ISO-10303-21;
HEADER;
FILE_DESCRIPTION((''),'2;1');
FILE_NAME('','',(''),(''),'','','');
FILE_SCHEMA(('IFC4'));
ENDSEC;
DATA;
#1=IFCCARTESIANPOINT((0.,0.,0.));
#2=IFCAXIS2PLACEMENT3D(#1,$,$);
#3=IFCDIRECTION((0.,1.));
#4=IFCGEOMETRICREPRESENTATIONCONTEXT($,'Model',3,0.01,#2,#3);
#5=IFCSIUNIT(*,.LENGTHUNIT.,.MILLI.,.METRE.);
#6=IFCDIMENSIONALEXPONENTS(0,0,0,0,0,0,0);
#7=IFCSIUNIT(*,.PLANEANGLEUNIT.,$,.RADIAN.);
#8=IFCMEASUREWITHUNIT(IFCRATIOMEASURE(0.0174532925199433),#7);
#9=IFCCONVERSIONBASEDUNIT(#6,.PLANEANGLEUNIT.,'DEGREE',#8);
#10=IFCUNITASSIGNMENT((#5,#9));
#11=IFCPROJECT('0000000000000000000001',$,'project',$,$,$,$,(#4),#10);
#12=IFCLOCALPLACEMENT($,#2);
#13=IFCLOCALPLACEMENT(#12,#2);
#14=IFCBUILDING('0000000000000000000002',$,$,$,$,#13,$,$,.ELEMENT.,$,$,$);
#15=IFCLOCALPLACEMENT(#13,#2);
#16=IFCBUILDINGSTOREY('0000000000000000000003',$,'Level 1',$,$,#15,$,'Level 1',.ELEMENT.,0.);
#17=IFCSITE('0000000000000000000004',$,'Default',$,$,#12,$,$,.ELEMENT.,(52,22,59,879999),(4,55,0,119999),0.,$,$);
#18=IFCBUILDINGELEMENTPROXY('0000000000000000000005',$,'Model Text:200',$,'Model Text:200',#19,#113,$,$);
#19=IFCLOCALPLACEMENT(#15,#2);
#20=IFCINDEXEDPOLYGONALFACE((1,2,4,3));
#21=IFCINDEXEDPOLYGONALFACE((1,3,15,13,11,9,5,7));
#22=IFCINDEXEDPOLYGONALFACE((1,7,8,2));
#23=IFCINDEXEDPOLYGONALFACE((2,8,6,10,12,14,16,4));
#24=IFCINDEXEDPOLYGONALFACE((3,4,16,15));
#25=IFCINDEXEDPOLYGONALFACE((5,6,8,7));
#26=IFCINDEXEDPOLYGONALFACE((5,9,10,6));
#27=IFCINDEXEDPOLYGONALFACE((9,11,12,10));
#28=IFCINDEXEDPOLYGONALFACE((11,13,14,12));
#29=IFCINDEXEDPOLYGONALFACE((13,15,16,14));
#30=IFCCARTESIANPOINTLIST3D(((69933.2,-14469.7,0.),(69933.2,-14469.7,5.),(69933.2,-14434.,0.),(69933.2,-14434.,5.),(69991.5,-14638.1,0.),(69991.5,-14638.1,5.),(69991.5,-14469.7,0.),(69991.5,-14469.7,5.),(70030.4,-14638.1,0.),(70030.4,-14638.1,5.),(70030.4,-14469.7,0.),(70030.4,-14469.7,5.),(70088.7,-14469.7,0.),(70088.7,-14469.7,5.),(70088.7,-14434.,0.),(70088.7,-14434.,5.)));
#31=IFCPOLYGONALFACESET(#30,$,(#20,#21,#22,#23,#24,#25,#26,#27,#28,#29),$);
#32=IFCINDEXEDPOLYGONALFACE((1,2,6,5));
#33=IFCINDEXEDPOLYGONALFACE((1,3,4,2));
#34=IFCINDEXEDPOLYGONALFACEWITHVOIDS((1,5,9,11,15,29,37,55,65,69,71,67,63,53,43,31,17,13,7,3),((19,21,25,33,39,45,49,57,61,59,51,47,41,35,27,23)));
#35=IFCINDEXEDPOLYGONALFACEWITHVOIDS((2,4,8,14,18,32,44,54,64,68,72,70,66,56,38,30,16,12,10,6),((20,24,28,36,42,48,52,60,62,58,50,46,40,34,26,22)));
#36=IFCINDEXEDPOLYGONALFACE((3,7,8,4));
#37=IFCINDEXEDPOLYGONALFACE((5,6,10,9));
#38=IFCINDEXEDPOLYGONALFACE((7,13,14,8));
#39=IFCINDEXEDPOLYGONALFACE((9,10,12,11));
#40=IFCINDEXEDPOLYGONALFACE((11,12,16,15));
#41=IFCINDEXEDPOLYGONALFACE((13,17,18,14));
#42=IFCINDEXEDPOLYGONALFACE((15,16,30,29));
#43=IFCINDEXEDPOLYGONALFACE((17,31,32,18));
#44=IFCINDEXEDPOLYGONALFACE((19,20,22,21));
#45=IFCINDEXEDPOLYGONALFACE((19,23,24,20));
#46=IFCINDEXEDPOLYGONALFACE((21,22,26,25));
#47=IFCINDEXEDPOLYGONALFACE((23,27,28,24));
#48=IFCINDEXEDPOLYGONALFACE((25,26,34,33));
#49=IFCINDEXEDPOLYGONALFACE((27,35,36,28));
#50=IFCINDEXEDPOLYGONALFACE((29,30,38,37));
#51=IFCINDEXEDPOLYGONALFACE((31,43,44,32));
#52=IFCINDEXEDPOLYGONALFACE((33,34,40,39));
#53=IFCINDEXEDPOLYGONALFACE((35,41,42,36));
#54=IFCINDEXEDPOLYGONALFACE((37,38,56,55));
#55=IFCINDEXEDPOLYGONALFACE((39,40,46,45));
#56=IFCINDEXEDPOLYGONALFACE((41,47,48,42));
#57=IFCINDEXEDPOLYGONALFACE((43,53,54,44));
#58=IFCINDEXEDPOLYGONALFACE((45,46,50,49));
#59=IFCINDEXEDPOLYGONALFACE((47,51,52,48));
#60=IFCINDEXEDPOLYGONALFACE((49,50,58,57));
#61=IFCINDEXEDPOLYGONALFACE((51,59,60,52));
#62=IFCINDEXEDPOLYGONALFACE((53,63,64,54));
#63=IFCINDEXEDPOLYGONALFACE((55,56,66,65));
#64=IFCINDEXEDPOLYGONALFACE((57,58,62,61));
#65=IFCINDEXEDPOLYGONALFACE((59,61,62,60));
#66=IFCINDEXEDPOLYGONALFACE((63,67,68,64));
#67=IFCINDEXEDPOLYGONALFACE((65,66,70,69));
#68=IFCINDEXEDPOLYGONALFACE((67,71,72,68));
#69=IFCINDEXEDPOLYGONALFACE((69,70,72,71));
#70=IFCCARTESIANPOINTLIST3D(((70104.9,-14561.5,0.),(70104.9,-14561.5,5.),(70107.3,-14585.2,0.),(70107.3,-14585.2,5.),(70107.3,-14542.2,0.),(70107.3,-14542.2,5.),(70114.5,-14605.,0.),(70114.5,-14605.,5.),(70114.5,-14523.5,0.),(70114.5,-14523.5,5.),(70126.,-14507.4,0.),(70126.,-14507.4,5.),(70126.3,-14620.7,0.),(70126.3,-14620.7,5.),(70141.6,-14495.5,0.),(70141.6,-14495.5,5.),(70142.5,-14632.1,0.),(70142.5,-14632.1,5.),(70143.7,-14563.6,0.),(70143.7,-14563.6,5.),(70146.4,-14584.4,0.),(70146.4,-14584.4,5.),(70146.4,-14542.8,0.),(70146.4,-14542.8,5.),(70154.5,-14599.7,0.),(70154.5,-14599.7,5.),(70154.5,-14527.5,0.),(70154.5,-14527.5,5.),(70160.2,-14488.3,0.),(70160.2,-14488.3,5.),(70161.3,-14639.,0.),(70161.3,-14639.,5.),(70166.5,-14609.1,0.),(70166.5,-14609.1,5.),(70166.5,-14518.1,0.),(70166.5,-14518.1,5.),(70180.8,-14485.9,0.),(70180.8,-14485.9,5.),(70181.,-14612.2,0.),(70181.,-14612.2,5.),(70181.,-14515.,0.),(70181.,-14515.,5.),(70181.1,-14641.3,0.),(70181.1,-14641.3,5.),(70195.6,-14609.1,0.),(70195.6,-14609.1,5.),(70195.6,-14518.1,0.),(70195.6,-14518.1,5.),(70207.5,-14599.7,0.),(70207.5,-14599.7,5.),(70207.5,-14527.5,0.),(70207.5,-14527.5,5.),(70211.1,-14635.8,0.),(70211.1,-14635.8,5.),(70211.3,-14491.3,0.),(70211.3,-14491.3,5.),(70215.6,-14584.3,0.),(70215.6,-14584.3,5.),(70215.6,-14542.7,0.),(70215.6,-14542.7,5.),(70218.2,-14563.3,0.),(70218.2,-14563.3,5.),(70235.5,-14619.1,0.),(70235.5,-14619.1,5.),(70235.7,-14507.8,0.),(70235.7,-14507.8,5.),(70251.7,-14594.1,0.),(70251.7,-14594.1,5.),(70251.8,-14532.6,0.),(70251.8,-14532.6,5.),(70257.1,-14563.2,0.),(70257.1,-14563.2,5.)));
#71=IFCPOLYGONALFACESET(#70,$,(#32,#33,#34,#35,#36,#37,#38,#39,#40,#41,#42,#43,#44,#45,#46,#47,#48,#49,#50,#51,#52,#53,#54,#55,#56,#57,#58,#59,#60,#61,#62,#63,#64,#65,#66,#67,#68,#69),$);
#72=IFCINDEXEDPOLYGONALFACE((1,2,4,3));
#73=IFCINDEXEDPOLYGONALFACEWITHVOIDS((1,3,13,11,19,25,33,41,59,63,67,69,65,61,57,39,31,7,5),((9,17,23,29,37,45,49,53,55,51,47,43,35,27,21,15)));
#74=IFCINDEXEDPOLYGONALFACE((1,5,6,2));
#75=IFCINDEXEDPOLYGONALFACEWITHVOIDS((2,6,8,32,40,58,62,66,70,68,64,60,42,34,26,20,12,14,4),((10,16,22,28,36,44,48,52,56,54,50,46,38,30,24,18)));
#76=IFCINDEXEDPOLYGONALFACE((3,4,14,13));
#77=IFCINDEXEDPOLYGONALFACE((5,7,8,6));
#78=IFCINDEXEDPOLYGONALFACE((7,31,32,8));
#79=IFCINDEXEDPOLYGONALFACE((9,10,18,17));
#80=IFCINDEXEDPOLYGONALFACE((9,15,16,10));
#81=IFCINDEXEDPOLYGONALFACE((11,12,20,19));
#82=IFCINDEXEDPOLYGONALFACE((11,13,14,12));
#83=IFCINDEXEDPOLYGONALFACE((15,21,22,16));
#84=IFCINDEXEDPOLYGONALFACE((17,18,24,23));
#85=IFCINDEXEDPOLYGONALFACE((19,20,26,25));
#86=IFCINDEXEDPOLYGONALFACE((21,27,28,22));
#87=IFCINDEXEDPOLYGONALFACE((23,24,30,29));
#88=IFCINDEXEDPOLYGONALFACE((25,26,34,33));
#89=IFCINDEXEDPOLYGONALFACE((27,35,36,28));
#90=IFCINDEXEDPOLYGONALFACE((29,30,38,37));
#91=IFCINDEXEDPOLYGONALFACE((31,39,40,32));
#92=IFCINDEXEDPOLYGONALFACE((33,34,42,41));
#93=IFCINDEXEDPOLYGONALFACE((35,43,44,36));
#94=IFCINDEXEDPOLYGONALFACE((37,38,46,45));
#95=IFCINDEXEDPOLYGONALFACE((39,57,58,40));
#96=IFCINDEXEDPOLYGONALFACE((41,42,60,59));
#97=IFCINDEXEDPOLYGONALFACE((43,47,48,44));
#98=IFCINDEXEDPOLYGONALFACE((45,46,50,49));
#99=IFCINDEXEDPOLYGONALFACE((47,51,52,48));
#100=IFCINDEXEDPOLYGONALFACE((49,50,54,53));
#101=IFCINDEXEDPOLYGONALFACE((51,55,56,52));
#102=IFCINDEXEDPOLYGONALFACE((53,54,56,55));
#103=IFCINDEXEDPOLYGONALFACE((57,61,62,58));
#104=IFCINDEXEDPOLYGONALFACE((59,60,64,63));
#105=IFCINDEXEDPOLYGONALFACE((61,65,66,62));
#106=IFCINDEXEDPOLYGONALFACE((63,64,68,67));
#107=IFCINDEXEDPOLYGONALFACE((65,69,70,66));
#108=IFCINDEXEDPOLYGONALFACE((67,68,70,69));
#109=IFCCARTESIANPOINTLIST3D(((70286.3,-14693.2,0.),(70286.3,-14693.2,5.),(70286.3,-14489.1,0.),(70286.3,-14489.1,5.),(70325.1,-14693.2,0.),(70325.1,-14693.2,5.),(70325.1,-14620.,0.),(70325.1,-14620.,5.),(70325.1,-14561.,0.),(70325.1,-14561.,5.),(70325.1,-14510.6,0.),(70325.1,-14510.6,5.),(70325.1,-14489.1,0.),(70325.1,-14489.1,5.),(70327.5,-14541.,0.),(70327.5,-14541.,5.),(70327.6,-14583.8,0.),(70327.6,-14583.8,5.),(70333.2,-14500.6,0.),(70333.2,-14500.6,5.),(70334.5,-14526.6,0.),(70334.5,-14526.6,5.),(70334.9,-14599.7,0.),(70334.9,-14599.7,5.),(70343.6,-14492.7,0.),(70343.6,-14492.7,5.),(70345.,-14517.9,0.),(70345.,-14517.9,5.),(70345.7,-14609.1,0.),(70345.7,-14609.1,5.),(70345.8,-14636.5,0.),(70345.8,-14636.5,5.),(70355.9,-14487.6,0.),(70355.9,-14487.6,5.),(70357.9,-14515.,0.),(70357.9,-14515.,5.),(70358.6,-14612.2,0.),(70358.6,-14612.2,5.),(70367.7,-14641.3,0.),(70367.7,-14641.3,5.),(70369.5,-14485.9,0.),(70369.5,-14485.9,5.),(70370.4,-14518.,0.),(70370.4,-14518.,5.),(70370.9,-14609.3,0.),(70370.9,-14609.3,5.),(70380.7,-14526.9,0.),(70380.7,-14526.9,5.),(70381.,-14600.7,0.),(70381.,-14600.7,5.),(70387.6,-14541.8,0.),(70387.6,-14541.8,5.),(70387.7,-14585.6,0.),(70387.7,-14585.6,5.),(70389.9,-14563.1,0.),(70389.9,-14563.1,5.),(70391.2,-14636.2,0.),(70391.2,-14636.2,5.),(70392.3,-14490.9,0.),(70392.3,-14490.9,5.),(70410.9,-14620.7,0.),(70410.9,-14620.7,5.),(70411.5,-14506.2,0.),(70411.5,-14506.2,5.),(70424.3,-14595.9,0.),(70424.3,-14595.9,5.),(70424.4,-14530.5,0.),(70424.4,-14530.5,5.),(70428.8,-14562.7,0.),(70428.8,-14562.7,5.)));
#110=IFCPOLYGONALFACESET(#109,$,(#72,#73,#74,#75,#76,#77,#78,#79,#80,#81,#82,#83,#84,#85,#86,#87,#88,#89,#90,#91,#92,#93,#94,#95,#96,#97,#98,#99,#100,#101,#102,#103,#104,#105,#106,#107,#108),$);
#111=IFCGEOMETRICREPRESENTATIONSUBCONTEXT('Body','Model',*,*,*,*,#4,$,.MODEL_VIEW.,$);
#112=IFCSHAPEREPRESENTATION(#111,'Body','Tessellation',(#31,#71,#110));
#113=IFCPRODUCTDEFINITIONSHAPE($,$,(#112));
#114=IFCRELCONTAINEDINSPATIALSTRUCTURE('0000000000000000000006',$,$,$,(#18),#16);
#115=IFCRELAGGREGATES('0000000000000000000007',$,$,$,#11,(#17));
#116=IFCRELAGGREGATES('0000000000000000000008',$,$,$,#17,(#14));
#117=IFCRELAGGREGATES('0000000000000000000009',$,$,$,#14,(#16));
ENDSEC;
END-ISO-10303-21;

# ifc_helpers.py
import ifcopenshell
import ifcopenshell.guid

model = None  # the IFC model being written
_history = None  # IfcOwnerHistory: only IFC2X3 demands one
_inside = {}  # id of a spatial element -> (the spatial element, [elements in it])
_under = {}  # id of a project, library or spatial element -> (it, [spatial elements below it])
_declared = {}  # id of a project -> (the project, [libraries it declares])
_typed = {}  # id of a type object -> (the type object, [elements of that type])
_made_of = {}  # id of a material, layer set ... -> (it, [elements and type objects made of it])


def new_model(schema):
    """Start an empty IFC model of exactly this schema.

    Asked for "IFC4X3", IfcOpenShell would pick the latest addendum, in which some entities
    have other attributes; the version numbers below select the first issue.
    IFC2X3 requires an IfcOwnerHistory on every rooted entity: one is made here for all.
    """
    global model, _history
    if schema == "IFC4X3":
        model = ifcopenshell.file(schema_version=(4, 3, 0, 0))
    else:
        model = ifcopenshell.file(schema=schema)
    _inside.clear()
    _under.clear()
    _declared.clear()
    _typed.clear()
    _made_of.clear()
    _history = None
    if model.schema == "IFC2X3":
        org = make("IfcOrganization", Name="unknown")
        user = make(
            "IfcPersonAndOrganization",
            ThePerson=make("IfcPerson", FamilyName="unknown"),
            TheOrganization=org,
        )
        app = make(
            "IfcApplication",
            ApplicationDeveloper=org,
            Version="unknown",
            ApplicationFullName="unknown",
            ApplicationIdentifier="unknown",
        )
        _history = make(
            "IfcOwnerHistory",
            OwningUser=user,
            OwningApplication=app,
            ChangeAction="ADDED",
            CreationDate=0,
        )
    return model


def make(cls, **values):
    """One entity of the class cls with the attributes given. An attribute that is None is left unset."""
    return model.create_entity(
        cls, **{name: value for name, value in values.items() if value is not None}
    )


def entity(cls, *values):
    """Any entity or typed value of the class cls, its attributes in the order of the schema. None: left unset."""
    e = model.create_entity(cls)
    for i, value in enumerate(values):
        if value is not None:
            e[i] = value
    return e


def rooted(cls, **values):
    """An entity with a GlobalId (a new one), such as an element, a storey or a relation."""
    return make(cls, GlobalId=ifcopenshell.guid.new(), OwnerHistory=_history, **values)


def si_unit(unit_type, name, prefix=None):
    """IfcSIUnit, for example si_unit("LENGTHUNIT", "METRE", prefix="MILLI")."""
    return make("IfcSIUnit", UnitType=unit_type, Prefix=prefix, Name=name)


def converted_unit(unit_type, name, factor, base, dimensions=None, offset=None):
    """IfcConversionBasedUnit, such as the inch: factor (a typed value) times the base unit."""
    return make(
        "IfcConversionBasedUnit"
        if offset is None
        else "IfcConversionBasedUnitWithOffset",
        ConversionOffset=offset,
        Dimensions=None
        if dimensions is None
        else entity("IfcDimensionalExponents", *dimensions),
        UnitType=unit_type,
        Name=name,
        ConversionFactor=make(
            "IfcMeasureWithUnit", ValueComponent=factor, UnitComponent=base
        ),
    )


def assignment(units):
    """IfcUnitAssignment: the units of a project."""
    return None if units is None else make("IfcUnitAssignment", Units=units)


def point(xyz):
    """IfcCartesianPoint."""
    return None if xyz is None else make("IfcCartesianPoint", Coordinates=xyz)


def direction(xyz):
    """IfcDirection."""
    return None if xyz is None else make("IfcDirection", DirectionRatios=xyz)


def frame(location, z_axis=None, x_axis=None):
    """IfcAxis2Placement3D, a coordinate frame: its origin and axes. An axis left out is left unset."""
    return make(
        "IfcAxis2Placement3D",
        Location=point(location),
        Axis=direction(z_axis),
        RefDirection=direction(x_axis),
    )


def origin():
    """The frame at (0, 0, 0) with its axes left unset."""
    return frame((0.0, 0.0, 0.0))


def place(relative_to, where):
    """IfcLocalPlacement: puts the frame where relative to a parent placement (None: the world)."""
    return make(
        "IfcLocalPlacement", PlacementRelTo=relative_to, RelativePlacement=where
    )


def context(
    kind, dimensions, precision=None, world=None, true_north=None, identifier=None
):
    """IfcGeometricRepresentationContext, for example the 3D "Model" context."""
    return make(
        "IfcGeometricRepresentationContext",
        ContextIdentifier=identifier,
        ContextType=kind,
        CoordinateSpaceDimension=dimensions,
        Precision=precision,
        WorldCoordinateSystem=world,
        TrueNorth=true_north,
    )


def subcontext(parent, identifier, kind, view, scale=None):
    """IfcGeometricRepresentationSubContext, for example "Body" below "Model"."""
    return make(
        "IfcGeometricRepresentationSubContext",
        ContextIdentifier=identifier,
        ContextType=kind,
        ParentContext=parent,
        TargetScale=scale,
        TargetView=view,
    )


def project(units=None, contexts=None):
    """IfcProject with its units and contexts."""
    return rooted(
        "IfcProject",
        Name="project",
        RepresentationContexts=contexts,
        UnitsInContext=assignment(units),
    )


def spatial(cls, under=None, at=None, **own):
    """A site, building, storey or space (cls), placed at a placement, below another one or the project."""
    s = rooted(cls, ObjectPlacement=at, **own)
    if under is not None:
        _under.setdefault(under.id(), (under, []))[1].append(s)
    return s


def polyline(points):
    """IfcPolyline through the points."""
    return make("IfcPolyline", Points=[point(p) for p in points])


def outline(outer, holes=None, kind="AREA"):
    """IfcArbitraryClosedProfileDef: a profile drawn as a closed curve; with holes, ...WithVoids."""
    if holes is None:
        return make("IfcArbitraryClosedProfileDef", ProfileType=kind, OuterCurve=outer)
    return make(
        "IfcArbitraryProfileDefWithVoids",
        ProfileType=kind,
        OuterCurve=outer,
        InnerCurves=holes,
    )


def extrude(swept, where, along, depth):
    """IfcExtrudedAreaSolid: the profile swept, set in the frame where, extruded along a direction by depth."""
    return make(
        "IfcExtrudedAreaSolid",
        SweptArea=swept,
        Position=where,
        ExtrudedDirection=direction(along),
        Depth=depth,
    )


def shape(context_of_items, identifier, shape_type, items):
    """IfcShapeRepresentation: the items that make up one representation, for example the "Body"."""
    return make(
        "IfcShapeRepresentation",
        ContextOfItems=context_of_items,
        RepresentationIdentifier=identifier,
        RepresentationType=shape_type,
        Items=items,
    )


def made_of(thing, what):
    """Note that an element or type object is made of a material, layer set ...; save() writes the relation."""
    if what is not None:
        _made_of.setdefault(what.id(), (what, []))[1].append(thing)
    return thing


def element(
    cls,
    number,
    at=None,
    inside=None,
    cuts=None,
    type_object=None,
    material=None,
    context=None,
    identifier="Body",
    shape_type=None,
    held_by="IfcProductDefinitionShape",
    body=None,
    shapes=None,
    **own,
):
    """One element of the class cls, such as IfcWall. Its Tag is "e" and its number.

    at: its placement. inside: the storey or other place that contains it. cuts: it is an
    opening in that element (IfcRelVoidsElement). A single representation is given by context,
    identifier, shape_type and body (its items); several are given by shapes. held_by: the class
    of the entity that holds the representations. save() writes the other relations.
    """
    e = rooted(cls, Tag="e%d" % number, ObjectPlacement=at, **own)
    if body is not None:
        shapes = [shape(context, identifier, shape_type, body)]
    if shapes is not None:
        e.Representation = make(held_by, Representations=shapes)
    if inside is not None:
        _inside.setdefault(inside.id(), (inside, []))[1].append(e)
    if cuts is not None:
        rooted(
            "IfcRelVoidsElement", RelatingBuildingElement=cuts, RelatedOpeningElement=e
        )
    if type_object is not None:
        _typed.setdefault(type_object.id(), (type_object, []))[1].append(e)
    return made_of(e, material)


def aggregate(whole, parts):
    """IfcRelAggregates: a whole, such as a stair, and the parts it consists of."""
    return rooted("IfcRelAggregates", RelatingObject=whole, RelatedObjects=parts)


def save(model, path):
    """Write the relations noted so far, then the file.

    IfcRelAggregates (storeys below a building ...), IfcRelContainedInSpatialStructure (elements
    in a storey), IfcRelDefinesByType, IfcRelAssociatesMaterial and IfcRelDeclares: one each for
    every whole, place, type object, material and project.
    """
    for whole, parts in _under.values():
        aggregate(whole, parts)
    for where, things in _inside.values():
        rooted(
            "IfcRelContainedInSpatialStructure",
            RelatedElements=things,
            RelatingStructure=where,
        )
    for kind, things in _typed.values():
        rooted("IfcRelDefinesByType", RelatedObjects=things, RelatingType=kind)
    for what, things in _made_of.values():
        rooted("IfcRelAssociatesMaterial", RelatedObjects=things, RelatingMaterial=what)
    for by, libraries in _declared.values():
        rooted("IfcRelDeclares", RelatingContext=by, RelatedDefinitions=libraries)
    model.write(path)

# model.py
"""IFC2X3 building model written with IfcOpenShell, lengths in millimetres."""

from ifc_helpers import new_model, entity, si_unit, converted_unit, direction, frame, origin, place, context, subcontext, project, spatial, polyline, outline, extrude, element, save


model = new_model("IFC2X3")

# Units and contexts
model_context = context("Model", 3, precision=0.01, world=origin(), true_north=direction((0.0, 1.0)))
body_context = subcontext(model_context, "Body", "Model", "MODEL_VIEW")
ifc_project = project(units=[si_unit("LENGTHUNIT", "METRE", prefix="MILLI"), converted_unit("PLANEANGLEUNIT", "DEGREE", entity("IfcRatioMeasure", 0.0174532925199433), si_unit("PLANEANGLEUNIT", "RADIAN"), dimensions=[0, 0, 0, 0, 0, 0, 0])], contexts=[model_context])

# Site, building, storey
site_placement = place(None, origin())
site = spatial("IfcSite", under=ifc_project, at=site_placement, Name="Default", CompositionType="ELEMENT", RefLatitude=(52, 22, 59, 879999), RefLongitude=(4, 55, 0, 119999), RefElevation=0.0)
building_placement = place(site_placement, origin())
building = spatial("IfcBuilding", under=site, at=building_placement, CompositionType="ELEMENT")
storey_placement = place(building_placement, origin())
storey = spatial("IfcBuildingStorey", under=building, at=storey_placement, Name="Level 1", LongName="Level 1", CompositionType="ELEMENT", Elevation=0.0)

# Building element proxy
proxy_1_placement = place(building_placement, origin())
element("IfcBuildingElementProxy", 1, at=proxy_1_placement, inside=storey, Name="Model Text:200", ObjectType="Model Text:200", context=body_context, shape_type="SweptSolid", body=[
    extrude(outline(polyline([(-19.4, -135.2), (19.4, -135.2), (19.4, 33.2), (77.7, 33.2), (77.7, 68.8), (-77.7, 68.8), (-77.7, 33.2), (-19.4, 33.2), (-19.4, -135.2)])), frame((70010.9, -14502.9, 0.0)), (0.0, 0.0, 1.0), 5.0),
    extrude(outline(polyline([(-8.8, -65.7), (15.1, -65.7), (35.5, -60.5), (52.3, -50.4), (65.3, -35.4), (74.1, -17.3), (78.4, 2.1), (75.9, 32.5), (61.8, 58.5), (38.4, 77.1), (8.3, 85.6), (-22.7, 83.3), (-49.0, 69.9), (-67.8, 47.3), (-76.3, 17.5), (-76.0, -3.3), (-70.7, -22.5), (-60.5, -39.2), (-45.5, -52.3), (-27.7, -61.4), (-8.8, -65.7)]), holes=[polyline([(-2.7, -27.2), (-23.1, -22.5), (-37.5, -12.9), (-45.7, 0.0), (-47.3, 14.8), (-42.7, 28.9), (-32.2, 39.9), (-16.3, 46.3), (4.5, 46.9), (25.1, 42.1), (39.6, 32.6), (47.7, 19.7), (49.4, 5.0), (44.8, -9.2), (34.2, -20.2), (18.2, -26.7), (-2.7, -27.2)])]), frame((70171.1, -14563.6, 0.0), z_axis=(0.0, 0.0, 1.0), x_axis=(0.100608, -0.994926, 0.0)), (0.0, 0.0, 1.0), 5.0),
    extrude(outline(polyline([(-73.1, -75.4), (130.9, -75.4), (130.9, -36.6), (57.8, -36.6), (74.3, -15.9), (79.1, 6.0), (73.9, 29.5), (58.4, 49.2), (33.6, 62.6), (0.5, 67.1), (-31.8, 62.8), (-56.1, 49.8), (-71.3, 30.7), (-76.4, 7.8), (-74.7, -5.8), (-69.6, -18.1), (-61.7, -28.5), (-51.7, -36.6), (-73.1, -36.6), (-73.1, -75.4)]), holes=[polyline([(-1.2, -36.6), (-21.2, -34.2), (-35.6, -27.2), (-44.3, -16.7), (-47.2, -3.8), (-44.3, 8.7), (-35.4, 19.0), (-20.4, 25.9), (0.8, 28.2), (23.3, 26.0), (38.5, 19.3), (47.1, 9.2), (49.9, -3.1), (46.8, -16.0), (37.4, -26.8), (21.5, -34.1), (-1.2, -36.6)])]), frame((70361.7, -14562.3, 0.0), z_axis=(0.0, 0.0, 1.0), x_axis=(0.0, -1.0, 0.0)), (0.0, 0.0, 1.0), 5.0),
])

save(model, "model.ifc")
